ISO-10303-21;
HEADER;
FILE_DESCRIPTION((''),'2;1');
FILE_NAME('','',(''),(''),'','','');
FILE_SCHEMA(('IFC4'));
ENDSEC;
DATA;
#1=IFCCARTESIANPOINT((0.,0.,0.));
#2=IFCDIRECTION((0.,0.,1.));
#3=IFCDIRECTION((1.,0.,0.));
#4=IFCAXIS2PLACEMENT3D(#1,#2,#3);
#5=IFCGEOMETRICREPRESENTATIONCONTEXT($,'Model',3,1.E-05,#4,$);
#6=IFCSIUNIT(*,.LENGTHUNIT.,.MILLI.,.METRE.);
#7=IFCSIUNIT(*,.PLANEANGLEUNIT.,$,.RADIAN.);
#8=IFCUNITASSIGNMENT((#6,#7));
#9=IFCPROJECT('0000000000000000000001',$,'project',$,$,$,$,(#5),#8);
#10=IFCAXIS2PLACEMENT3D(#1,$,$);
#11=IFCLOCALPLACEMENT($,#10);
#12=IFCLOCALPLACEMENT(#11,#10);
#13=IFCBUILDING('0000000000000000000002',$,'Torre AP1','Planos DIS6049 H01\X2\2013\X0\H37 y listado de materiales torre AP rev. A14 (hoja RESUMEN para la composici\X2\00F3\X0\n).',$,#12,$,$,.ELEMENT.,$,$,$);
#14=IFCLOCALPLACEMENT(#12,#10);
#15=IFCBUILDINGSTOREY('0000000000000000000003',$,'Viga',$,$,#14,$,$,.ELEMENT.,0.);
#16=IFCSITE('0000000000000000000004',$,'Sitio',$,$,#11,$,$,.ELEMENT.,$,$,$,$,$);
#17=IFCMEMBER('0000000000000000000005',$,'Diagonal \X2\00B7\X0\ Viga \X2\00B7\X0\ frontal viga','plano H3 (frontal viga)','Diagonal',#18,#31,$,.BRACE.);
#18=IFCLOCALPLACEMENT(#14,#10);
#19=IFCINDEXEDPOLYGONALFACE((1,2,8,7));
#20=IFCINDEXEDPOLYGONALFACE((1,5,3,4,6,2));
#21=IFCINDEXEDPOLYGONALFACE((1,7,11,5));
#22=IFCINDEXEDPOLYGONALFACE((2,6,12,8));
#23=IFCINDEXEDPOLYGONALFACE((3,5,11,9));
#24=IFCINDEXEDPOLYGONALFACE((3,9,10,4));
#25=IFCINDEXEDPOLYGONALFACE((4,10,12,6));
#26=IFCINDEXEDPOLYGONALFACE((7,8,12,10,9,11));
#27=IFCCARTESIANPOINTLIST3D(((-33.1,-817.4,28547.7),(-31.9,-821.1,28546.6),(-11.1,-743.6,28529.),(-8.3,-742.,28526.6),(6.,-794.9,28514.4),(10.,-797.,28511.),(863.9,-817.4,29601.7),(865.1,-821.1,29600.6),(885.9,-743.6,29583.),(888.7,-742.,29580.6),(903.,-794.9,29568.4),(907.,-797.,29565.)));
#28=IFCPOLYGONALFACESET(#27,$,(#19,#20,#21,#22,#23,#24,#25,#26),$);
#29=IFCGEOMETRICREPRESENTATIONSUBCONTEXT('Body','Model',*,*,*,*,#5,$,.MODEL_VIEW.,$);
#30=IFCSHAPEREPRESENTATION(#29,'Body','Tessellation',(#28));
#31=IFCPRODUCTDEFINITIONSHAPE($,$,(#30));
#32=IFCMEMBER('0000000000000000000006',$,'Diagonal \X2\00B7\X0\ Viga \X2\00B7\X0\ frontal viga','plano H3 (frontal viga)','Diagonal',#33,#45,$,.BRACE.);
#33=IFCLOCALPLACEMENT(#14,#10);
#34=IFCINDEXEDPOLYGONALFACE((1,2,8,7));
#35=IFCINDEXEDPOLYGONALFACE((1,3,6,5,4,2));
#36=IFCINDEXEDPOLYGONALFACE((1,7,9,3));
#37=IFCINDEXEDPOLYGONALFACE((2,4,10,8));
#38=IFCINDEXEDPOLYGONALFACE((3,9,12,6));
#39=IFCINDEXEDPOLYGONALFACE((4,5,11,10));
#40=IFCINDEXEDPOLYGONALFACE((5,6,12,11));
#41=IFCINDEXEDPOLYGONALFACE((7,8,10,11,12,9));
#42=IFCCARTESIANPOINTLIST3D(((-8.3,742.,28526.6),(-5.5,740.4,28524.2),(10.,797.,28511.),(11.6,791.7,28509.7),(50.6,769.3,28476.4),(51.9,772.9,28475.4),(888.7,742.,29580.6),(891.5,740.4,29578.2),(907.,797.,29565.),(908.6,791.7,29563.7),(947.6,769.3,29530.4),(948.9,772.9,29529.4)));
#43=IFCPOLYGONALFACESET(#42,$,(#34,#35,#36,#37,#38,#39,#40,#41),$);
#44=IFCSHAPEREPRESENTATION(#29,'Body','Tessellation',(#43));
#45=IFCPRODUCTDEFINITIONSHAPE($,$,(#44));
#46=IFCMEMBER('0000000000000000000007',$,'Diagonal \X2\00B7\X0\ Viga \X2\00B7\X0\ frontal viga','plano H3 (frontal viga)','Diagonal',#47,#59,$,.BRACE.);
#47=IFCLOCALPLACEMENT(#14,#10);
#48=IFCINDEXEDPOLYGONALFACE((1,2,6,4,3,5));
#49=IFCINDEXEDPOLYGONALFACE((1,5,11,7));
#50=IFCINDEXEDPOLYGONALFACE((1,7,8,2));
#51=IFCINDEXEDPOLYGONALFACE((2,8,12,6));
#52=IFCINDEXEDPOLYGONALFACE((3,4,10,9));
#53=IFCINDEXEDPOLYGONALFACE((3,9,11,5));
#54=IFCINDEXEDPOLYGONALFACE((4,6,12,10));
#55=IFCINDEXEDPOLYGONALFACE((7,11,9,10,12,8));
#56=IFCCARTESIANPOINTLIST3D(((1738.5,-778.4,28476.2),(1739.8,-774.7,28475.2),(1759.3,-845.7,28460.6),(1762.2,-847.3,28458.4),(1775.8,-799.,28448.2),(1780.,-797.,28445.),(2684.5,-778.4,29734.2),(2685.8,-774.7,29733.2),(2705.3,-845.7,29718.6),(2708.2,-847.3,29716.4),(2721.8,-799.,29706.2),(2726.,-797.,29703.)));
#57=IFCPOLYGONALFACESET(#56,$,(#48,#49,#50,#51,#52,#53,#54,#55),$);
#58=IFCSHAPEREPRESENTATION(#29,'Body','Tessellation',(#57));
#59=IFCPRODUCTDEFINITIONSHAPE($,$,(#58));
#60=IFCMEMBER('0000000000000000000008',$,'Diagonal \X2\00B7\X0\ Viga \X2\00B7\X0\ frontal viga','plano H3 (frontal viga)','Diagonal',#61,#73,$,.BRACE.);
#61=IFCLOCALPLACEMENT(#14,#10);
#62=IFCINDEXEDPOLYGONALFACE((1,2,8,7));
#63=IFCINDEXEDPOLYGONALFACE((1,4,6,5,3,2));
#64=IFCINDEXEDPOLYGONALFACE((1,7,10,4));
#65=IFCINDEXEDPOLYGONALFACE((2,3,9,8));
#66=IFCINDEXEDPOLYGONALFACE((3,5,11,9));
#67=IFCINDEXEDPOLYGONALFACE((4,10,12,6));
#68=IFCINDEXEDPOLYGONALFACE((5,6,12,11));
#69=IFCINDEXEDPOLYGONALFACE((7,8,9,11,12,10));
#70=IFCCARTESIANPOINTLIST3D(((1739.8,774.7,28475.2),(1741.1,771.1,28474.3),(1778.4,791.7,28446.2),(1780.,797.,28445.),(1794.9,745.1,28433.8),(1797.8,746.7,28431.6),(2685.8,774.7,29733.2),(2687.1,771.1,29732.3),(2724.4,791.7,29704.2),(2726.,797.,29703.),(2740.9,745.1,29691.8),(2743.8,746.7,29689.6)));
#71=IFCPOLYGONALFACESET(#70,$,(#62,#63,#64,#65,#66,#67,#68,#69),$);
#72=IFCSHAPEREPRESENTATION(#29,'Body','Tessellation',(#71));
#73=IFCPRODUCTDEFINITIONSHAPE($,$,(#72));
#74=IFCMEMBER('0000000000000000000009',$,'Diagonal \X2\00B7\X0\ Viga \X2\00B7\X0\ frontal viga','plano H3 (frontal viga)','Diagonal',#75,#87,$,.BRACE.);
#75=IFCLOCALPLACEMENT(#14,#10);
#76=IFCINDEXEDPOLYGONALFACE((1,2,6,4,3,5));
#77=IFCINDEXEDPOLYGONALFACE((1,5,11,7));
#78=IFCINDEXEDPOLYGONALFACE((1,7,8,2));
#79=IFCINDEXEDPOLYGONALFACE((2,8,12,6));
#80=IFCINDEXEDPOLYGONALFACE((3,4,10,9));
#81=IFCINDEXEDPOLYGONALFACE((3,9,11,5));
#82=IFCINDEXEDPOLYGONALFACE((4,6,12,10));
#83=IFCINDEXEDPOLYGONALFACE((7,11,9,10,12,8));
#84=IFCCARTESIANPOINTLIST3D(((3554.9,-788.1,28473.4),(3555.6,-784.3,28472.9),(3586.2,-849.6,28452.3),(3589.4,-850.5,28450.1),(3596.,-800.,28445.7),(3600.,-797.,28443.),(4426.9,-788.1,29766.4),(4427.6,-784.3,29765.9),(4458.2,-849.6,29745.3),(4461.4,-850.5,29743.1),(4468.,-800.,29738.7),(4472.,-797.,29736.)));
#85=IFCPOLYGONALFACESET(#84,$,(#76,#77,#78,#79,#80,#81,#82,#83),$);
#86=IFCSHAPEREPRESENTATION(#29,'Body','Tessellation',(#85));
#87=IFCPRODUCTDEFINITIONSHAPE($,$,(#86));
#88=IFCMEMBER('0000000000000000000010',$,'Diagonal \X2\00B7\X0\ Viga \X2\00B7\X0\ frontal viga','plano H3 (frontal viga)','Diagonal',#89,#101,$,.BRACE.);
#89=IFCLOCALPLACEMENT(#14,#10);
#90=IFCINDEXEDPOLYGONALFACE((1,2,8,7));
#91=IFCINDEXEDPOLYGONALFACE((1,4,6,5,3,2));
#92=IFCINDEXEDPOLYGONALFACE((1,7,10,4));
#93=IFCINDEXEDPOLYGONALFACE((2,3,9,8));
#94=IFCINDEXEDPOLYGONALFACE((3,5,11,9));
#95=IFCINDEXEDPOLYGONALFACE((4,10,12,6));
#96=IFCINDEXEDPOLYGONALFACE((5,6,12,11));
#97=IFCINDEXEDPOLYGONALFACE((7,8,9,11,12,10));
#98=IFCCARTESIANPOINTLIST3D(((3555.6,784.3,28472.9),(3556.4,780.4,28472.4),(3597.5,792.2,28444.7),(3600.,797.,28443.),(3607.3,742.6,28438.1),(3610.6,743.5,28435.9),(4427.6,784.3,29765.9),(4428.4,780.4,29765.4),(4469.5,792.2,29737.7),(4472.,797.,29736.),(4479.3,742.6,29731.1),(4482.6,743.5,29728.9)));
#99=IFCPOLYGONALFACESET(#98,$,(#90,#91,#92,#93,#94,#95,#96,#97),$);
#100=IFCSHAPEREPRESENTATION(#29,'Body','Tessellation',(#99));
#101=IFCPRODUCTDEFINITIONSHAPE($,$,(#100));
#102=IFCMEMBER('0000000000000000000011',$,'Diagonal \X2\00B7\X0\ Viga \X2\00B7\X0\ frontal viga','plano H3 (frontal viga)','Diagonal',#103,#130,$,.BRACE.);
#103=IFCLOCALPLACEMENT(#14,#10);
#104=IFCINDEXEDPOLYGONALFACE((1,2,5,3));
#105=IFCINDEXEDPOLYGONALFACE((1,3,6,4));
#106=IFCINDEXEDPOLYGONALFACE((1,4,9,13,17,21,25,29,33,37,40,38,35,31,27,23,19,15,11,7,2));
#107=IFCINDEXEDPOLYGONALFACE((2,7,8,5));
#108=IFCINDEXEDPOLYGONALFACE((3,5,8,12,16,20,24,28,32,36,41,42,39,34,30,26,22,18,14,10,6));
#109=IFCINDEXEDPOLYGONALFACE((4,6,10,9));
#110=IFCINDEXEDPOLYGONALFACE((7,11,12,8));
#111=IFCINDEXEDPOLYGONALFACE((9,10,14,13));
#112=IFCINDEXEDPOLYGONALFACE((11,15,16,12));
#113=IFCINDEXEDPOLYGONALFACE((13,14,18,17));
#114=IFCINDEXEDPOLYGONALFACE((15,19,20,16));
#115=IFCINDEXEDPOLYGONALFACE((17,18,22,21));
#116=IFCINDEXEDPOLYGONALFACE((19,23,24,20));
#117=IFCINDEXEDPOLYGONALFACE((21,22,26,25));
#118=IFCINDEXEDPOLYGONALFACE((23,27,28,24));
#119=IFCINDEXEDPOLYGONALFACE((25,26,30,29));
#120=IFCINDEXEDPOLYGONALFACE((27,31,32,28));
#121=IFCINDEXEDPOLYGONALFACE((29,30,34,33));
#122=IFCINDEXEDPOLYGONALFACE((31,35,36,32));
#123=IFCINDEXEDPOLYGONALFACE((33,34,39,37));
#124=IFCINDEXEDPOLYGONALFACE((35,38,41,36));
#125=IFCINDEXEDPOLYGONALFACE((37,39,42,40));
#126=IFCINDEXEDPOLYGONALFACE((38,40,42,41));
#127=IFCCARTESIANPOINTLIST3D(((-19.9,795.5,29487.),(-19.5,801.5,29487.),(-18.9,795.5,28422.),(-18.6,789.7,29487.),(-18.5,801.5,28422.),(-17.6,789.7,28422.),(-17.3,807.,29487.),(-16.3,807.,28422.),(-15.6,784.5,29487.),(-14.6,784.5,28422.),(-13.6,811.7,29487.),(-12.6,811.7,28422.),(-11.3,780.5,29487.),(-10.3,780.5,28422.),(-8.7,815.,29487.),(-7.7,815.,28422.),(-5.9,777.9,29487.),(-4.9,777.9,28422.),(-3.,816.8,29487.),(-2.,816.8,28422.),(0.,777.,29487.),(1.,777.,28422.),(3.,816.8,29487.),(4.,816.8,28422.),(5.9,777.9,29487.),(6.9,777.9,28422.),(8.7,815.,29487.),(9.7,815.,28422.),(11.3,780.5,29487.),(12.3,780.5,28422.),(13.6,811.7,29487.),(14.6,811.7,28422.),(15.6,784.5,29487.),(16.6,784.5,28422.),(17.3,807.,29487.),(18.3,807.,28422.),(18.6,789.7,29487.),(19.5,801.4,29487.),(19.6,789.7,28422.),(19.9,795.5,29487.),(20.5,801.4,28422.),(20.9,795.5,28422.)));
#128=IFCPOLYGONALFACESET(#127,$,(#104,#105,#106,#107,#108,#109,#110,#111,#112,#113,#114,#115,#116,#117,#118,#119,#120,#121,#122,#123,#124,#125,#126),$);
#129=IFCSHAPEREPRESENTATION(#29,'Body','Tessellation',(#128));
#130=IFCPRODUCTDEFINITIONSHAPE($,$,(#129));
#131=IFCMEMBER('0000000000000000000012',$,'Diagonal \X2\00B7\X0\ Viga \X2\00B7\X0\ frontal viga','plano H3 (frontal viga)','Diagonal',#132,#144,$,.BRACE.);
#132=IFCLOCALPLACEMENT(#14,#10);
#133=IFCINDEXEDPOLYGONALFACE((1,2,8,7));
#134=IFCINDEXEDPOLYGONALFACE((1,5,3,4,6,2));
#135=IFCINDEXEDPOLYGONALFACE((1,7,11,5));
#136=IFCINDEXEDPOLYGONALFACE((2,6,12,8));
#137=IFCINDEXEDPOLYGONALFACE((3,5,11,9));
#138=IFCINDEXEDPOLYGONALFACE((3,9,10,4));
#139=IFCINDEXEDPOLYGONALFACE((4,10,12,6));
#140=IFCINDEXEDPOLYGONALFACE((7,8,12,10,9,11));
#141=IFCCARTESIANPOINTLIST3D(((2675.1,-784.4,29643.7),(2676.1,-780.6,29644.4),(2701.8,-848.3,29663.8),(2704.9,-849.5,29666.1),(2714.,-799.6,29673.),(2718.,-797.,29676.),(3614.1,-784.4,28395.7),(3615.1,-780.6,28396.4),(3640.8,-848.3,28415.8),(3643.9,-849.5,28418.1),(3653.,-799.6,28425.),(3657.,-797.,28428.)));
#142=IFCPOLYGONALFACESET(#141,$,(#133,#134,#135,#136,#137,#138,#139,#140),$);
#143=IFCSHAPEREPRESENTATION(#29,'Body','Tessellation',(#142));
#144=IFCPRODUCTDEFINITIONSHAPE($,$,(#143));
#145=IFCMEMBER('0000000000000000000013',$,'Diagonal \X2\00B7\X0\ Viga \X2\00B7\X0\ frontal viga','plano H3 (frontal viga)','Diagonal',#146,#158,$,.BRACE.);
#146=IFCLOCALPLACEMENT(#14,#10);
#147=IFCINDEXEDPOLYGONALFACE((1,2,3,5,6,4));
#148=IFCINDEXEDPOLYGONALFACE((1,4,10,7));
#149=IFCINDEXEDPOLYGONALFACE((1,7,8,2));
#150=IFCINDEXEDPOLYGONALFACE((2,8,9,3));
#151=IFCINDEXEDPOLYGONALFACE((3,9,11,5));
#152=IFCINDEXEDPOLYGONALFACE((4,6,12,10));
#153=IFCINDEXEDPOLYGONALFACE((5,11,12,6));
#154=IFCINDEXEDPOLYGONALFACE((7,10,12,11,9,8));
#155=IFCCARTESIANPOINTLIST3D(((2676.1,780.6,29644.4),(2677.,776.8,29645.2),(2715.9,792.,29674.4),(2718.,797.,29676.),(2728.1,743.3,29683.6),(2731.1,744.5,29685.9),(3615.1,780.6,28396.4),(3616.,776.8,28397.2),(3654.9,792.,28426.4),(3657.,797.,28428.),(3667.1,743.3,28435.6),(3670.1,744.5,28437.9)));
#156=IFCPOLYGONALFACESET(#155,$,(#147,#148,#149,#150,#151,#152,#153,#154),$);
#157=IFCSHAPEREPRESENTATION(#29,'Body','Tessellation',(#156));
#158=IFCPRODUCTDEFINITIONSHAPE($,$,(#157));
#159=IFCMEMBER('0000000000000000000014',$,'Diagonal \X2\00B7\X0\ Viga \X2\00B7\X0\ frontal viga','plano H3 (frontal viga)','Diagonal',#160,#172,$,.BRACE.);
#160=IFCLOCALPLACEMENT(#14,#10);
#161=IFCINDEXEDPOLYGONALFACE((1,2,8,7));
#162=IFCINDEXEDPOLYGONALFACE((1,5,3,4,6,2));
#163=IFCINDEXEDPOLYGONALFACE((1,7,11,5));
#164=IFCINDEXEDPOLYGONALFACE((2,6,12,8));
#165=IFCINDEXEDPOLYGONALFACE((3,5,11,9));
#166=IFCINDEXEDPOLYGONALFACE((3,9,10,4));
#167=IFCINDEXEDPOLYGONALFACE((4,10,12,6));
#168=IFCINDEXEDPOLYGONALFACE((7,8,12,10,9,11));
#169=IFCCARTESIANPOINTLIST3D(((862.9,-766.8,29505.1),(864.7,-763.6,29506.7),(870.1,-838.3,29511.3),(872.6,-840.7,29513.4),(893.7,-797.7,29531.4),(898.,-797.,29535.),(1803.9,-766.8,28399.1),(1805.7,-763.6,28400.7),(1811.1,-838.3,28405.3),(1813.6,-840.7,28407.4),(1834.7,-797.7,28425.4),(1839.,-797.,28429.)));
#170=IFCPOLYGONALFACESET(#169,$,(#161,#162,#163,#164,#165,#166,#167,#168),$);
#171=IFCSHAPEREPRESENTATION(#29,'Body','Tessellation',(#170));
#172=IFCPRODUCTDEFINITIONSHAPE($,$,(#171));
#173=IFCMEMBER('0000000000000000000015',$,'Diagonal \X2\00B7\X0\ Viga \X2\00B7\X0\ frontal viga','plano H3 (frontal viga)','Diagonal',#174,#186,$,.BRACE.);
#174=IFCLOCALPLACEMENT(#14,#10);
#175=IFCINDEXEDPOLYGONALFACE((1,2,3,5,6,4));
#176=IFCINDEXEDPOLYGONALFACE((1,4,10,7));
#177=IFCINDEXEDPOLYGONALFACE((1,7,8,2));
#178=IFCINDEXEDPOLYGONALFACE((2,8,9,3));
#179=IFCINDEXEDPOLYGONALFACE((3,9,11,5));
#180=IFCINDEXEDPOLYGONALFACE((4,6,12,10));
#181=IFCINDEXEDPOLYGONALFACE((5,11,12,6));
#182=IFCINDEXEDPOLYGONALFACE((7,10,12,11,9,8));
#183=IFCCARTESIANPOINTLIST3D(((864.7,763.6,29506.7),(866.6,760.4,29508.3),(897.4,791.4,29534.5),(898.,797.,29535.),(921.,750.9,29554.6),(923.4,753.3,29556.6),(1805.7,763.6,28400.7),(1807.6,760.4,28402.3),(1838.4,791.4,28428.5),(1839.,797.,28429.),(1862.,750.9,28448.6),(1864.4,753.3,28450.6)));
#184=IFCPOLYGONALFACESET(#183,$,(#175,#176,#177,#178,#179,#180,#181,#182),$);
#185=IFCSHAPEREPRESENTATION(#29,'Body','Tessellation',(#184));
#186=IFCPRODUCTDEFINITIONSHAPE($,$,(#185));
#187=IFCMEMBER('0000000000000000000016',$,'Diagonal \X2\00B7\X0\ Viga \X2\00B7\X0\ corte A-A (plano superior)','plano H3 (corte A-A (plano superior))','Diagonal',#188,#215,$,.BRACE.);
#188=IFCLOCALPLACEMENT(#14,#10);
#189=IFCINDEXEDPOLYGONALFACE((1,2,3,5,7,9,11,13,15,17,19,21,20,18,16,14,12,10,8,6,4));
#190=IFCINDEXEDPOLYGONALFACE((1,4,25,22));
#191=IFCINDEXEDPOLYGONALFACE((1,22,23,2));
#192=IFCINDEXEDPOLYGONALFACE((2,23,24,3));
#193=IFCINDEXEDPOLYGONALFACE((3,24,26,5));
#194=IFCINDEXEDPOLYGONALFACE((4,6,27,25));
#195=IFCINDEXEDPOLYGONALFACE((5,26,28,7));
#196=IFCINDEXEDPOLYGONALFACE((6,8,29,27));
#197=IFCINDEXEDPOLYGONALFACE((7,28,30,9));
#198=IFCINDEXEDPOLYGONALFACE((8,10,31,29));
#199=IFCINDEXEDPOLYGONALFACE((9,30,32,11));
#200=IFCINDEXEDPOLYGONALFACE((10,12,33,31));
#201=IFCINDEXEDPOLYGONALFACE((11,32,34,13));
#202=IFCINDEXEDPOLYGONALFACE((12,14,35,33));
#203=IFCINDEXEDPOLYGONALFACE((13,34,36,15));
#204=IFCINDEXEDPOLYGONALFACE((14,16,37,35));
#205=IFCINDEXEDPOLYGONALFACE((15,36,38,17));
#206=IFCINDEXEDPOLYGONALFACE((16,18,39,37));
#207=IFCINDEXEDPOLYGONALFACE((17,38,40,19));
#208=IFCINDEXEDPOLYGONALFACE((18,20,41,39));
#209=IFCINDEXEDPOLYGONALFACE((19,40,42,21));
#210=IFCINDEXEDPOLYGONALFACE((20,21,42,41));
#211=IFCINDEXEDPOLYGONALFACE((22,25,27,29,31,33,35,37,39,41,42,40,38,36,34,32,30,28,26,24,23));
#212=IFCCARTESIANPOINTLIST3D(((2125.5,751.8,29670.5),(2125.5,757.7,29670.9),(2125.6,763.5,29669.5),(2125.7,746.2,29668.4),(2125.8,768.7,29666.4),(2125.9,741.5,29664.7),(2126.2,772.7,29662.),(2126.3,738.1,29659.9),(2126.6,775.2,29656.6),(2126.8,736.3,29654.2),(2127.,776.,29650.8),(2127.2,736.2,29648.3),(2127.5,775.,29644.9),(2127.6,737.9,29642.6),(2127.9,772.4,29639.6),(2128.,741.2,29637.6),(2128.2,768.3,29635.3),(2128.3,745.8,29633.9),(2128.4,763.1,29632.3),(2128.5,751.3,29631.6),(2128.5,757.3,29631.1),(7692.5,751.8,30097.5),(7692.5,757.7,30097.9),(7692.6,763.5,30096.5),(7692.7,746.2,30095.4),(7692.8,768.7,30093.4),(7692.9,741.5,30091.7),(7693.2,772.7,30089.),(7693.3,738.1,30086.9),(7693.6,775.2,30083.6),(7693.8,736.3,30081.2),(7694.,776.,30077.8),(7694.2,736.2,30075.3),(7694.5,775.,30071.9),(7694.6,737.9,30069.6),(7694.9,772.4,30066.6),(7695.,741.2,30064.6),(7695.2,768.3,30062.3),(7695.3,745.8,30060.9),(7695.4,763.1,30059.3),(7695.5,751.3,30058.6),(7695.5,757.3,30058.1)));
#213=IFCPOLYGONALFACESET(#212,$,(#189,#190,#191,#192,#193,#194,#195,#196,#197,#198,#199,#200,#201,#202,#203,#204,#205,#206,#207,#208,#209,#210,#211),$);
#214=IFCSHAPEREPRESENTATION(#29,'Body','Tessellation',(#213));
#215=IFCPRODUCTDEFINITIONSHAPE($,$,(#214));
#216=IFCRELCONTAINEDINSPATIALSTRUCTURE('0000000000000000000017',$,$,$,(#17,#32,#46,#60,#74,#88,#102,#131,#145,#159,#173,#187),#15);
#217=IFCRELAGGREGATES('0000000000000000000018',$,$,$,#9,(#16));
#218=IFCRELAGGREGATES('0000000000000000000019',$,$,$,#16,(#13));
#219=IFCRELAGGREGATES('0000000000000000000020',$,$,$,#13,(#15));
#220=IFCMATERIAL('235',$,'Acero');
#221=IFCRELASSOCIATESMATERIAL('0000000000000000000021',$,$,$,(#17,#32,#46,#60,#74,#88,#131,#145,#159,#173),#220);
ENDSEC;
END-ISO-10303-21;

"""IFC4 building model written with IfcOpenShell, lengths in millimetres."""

from ifc_helpers import new_model, si_unit, frame, frame_2d, origin, origin_with_axes, place, context, subcontext, project, spatial, circle, l_section, extrude, material, element, save


model = new_model("IFC4")

# Units and contexts
model_context = context("Model", 3, precision=1e-05, world=origin_with_axes())
body_context = subcontext(model_context, "Body", "Model", "MODEL_VIEW")
ifc_project = project(units=[si_unit("LENGTHUNIT", "METRE", prefix="MILLI"), si_unit("PLANEANGLEUNIT", "RADIAN")], contexts=[model_context])

# Site, building, storey
site_placement = place(None, origin())
site = spatial("IfcSite", under=ifc_project, at=site_placement, Name="Sitio", CompositionType="ELEMENT")
building_placement = place(site_placement, origin())
building = spatial("IfcBuilding", under=site, at=building_placement, Name="Torre AP1", Description="Planos DIS6049 H01–H37 y listado de materiales torre AP rev. A14 (hoja RESUMEN para la composición).", CompositionType="ELEMENT")
storey_placement = place(building_placement, origin())
storey = spatial("IfcBuildingStorey", under=building, at=storey_placement, Name="Viga", CompositionType="ELEMENT", Elevation=0.0)

# Members
ifc_material = material(Name="235", Category="Acero")
for number, where, z_axis, x_axis, name in (
    (1, (10.0, -797.0, 28511.0), (0.64811, 0.0, 0.761547), (-0.305596, 0.915954, 0.260076), "Diagonal · Viga · frontal viga"),
    (2, (10.0, 797.0, 28511.0), (0.64811, 0.0, 0.761547), (-0.305596, -0.915954, 0.260076), "Diagonal · Viga · frontal viga"),
):
    element("IfcMember", number, at=place(storey_placement, frame(where, z_axis=z_axis, x_axis=x_axis)), inside=storey, material=ifc_material, Name=name, Description="plano H3 (frontal viga)", ObjectType="Diagonal", PredefinedType="BRACE", context=body_context, shape_type="SweptSolid", body=[
        extrude(l_section(Depth=60.0, Width=60.0, Thickness=4.0, at=frame_2d((30.0, 30.0))), None, (0.0, 0.0, 1.0), 1384.0),
    ])
for number, where, z_axis, x_axis, name in (
    (3, (1780.0, -797.0, 28445.0), (0.601016, 0.0, 0.799237), (-0.730849, 0.404737, 0.549589), "Diagonal · Viga · frontal viga"),
    (4, (1780.0, 797.0, 28445.0), (0.601016, 0.0, 0.799237), (-0.730849, -0.404737, 0.549589), "Diagonal · Viga · frontal viga"),
):
    element("IfcMember", number, at=place(storey_placement, frame(where, z_axis=z_axis, x_axis=x_axis)), inside=storey, material=ifc_material, Name=name, Description="plano H3 (frontal viga)", ObjectType="Diagonal", PredefinedType="BRACE", context=body_context, shape_type="SweptSolid", body=[
        extrude(l_section(Depth=55.0, Width=55.0, Thickness=4.0, at=frame_2d((27.5, 27.5))), None, (0.0, 0.0, 1.0), 1574.0),
    ])
for number, where, z_axis, x_axis, name in (
    (5, (3600.0, -797.0, 28443.0), (0.559131, 0.0, 0.829079), (-0.806517, 0.231702, 0.543916), "Diagonal · Viga · frontal viga"),
    (6, (3600.0, 797.0, 28443.0), (0.559131, 0.0, 0.829079), (-0.806517, -0.231702, 0.543916), "Diagonal · Viga · frontal viga"),
):
    element("IfcMember", number, at=place(storey_placement, frame(where, z_axis=z_axis, x_axis=x_axis)), inside=storey, material=ifc_material, Name=name, Description="plano H3 (frontal viga)", ObjectType="Diagonal", PredefinedType="BRACE", context=body_context, shape_type="SweptSolid", body=[
        extrude(l_section(Depth=55.0, Width=55.0, Thickness=4.0, at=frame_2d((27.5, 27.5))), None, (0.0, 0.0, 1.0), 1559.6),
    ])
member_1_placement = place(storey_placement, frame((1.0, 797.0, 28422.0), z_axis=(-0.000939, 0.0, 1.0), x_axis=(-0.000627, -1.0, -0.000001)))
element("IfcMember", 7, at=member_1_placement, inside=storey, Name="Diagonal · Viga · frontal viga", Description="plano H3 (frontal viga)", ObjectType="Diagonal", PredefinedType="BRACE", context=body_context, shape_type="SweptSolid", body=[
    extrude(circle(Radius=20.0), None, (0.0, 0.0, 1.0), 1065.0),
])
for number, where, z_axis, x_axis, name in (
    (8, (3657.0, -797.0, 28428.0), (-0.601229, 0.0, 0.799077), (-0.762614, 0.298631, -0.573794), "Diagonal · Viga · frontal viga"),
    (9, (3657.0, 797.0, 28428.0), (-0.601229, 0.0, 0.799077), (-0.762614, -0.298631, -0.573794), "Diagonal · Viga · frontal viga"),
):
    element("IfcMember", number, at=place(storey_placement, frame(where, z_axis=z_axis, x_axis=x_axis)), inside=storey, material=ifc_material, Name=name, Description="plano H3 (frontal viga)", ObjectType="Diagonal", PredefinedType="BRACE", context=body_context, shape_type="SweptSolid", body=[
        extrude(l_section(Depth=55.0, Width=55.0, Thickness=4.0, at=frame_2d((27.5, 27.5))), None, (0.0, 0.0, 1.0), 1561.8),
    ])
for number, where, z_axis, x_axis, name in (
    (10, (1839.0, -797.0, 28429.0), (-0.648008, 0.0, 0.761633), (-0.605023, 0.607426, -0.514762), "Diagonal · Viga · frontal viga"),
    (11, (1839.0, 797.0, 28429.0), (-0.648008, 0.0, 0.761633), (-0.605023, -0.607426, -0.514762), "Diagonal · Viga · frontal viga"),
):
    element("IfcMember", number, at=place(storey_placement, frame(where, z_axis=z_axis, x_axis=x_axis)), inside=storey, material=ifc_material, Name=name, Description="plano H3 (frontal viga)", ObjectType="Diagonal", PredefinedType="BRACE", context=body_context, shape_type="SweptSolid", body=[
        extrude(l_section(Depth=55.0, Width=55.0, Thickness=4.0, at=frame_2d((27.5, 27.5))), None, (0.0, 0.0, 1.0), 1452.1),
    ])
member_2_placement = place(storey_placement, frame((2127.0, 756.0, 29651.0), z_axis=(0.997071, 0.0, 0.076477), x_axis=(-0.034023, -0.895589, 0.44358)))
element("IfcMember", 12, at=member_2_placement, inside=storey, Name="Diagonal · Viga · corte A-A (plano superior)", Description="plano H3 (corte A-A (plano superior))", ObjectType="Diagonal", PredefinedType="BRACE", context=body_context, shape_type="SweptSolid", body=[
    extrude(circle(Radius=20.0), None, (0.0, 0.0, 1.0), 5583.4),
])

save(model, "model.ifc")
